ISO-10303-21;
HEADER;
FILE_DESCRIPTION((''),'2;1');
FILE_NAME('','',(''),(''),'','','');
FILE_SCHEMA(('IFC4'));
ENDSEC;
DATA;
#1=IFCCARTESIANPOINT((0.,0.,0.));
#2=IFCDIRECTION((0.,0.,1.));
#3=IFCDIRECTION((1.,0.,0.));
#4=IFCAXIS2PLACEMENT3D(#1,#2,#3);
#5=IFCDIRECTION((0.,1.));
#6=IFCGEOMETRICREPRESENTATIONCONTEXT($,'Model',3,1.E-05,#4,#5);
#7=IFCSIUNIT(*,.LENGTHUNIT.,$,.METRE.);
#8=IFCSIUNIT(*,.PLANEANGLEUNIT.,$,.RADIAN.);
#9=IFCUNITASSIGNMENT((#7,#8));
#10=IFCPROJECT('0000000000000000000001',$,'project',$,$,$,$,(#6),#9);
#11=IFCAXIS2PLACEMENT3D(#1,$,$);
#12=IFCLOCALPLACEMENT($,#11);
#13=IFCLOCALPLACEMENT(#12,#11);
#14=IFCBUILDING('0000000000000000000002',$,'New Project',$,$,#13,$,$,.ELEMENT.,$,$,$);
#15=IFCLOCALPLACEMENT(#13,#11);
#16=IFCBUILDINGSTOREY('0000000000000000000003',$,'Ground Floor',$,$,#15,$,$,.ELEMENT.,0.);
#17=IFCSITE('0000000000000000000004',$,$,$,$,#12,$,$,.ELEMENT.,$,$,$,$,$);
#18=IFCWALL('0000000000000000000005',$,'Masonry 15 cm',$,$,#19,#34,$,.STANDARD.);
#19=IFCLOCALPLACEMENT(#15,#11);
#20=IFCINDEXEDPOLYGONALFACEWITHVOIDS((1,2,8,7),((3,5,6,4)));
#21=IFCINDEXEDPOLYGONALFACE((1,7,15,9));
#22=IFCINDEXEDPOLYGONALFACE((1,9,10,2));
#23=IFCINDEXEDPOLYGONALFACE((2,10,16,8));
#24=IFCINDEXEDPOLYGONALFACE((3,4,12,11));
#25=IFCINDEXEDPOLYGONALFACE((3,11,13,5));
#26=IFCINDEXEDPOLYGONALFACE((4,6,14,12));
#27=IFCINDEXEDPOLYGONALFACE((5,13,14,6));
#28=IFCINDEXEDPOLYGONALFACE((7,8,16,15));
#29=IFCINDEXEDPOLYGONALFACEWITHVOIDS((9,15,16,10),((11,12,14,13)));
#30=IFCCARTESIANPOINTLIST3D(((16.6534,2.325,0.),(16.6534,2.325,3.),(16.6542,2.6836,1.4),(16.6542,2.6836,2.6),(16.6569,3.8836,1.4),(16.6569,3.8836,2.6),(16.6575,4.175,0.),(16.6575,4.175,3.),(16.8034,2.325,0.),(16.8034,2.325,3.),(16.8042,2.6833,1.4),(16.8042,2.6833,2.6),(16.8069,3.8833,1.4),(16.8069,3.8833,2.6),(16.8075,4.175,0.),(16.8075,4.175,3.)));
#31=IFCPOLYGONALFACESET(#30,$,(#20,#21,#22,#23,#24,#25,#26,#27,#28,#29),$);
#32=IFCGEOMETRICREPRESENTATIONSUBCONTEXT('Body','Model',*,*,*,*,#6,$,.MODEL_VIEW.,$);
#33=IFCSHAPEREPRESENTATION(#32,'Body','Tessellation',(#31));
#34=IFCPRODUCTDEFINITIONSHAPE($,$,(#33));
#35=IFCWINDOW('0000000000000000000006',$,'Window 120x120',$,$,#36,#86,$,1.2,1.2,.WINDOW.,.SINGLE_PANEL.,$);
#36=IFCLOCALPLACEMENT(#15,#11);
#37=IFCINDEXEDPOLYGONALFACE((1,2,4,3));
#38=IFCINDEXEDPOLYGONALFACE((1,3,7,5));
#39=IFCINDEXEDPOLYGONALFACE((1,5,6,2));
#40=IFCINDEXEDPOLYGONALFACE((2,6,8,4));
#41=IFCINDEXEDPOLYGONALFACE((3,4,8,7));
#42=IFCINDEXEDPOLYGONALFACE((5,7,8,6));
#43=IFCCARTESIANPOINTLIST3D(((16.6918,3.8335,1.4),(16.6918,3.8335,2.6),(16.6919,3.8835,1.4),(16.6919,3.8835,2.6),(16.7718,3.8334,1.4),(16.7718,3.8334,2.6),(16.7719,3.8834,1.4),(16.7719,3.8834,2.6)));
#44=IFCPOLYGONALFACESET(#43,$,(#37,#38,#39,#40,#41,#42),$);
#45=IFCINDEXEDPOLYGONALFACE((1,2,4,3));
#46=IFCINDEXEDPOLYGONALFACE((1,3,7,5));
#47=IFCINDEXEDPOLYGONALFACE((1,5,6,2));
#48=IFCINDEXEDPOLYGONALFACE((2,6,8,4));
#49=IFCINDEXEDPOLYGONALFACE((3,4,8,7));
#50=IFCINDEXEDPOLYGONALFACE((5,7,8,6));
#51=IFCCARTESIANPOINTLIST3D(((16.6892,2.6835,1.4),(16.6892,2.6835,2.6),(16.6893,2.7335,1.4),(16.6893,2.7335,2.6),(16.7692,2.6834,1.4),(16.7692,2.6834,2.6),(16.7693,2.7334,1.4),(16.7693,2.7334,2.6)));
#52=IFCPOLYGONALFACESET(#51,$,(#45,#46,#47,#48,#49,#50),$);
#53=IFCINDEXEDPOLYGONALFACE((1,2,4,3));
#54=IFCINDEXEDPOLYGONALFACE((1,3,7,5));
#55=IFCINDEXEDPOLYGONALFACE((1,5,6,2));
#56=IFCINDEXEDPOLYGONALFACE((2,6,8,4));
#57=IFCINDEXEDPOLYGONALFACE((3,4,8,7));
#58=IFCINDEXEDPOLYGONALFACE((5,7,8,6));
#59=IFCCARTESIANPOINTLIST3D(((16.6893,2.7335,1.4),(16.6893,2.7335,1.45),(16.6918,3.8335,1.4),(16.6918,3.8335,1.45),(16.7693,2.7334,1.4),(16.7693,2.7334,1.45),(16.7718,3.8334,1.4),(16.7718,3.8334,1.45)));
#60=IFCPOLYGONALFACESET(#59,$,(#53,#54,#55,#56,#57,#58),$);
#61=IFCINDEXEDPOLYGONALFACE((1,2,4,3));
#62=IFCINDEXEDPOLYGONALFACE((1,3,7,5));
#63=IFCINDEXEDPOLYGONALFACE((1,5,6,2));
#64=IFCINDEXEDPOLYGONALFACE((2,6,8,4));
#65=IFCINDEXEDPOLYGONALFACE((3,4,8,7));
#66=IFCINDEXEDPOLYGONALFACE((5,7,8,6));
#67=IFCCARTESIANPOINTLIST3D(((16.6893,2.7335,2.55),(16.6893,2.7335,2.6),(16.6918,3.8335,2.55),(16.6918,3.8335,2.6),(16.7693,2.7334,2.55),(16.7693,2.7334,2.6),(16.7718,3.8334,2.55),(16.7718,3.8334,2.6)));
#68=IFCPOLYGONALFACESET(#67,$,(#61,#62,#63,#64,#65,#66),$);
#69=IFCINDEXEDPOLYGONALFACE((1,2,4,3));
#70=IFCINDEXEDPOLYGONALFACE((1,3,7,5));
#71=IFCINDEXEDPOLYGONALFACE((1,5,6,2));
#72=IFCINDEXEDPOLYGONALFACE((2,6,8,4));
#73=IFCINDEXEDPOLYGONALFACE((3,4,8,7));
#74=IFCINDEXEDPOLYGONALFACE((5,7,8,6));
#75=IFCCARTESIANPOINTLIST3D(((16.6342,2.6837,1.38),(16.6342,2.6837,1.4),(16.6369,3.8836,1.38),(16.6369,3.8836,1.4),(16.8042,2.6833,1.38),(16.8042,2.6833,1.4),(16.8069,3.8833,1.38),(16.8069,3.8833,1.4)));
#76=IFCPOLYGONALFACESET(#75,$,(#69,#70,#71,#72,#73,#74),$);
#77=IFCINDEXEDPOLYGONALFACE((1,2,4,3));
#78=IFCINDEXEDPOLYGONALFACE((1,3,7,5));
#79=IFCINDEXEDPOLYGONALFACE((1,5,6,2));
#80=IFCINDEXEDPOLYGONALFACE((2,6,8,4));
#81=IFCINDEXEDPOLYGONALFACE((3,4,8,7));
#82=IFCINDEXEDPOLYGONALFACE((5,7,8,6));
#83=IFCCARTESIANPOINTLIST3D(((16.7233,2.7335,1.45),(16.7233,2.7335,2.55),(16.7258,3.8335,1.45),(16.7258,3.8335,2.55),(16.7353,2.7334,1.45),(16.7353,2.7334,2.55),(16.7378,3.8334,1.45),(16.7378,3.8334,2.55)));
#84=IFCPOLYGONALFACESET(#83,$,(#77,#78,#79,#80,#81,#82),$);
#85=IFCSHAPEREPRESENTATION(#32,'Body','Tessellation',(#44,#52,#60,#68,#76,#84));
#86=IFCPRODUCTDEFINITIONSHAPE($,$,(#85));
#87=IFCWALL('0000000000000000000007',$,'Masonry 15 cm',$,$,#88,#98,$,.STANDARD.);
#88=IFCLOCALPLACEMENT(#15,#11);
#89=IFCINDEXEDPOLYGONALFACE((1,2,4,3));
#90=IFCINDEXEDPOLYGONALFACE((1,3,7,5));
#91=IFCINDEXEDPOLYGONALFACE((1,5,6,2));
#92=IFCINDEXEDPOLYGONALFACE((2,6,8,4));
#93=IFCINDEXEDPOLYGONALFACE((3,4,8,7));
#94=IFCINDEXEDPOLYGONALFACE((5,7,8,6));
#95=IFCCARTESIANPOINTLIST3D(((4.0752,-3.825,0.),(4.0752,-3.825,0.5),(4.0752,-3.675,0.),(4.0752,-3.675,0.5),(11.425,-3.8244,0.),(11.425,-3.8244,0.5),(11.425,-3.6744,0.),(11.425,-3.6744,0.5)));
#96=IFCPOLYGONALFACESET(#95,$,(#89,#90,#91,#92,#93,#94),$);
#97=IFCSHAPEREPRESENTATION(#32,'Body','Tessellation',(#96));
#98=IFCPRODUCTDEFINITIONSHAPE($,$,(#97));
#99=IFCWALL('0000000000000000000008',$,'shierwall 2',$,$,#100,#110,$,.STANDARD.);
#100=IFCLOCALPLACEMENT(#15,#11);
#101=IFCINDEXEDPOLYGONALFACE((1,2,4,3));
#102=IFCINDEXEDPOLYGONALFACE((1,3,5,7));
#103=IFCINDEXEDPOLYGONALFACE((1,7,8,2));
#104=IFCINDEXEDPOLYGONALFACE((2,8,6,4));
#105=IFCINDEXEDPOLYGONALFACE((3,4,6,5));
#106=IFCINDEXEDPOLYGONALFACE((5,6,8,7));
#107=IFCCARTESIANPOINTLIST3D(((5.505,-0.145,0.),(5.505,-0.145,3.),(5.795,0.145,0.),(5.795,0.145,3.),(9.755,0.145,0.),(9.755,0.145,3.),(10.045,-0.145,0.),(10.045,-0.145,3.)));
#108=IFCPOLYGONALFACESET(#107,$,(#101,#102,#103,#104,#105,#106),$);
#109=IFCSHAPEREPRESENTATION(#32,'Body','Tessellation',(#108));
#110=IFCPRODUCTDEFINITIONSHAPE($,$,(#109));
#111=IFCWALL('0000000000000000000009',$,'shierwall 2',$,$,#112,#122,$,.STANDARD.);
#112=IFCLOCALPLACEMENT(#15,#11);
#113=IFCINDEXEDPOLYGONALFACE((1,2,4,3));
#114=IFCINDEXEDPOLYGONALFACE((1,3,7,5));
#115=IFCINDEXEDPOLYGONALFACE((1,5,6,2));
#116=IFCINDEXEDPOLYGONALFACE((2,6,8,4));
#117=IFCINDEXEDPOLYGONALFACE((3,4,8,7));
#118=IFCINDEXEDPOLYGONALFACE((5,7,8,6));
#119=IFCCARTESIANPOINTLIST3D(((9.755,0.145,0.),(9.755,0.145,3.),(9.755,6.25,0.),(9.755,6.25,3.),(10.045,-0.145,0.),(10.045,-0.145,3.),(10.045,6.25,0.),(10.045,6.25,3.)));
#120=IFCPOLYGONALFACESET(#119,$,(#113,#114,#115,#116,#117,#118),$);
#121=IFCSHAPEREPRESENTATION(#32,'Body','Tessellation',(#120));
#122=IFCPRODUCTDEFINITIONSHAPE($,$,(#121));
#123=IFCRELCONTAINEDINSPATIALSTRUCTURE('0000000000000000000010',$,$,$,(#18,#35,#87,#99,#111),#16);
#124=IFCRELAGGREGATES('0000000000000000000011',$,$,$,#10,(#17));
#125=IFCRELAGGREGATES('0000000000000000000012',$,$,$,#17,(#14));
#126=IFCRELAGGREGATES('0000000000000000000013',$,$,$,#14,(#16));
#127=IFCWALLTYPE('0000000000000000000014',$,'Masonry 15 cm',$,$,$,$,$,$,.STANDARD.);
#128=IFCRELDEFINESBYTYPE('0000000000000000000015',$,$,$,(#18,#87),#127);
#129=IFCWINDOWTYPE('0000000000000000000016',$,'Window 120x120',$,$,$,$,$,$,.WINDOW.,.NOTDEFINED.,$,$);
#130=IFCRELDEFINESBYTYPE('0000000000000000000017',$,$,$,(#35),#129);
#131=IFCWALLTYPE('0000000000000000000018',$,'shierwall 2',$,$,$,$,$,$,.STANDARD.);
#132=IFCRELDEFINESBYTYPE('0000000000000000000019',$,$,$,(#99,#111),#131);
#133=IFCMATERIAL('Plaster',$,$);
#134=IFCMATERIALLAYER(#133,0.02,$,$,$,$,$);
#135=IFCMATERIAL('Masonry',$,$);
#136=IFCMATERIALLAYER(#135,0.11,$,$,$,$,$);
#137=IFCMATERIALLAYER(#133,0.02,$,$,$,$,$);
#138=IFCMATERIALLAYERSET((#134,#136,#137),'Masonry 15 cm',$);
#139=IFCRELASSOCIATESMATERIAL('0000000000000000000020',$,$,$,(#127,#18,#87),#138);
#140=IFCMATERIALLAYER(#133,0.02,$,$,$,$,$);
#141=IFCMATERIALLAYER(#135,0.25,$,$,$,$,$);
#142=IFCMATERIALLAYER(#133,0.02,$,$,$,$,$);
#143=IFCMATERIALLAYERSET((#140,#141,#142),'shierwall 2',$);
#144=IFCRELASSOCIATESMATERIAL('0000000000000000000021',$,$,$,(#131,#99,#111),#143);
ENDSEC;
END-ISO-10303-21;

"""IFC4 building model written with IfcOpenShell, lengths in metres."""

from ifc_helpers import new_model, si_unit, direction, frame, frame_2d, origin, origin_with_axes, place, context, subcontext, project, spatial, polyline, rectangle, outline, extrude, material, layer, layer_set, layer_usage, type_object, element, fill, save


model = new_model("IFC4")

# Units and contexts
model_context = context("Model", 3, precision=1e-05, world=origin_with_axes(), true_north=direction((0.0, 1.0)))
body_context = subcontext(model_context, "Body", "Model", "MODEL_VIEW")
ifc_project = project(units=[si_unit("LENGTHUNIT", "METRE"), si_unit("PLANEANGLEUNIT", "RADIAN")], contexts=[model_context])

# Site, building, storey
site_placement = place(None, origin())
site = spatial("IfcSite", under=ifc_project, at=site_placement, CompositionType="ELEMENT")
building_placement = place(site_placement, origin())
building = spatial("IfcBuilding", under=site, at=building_placement, Name="New Project", CompositionType="ELEMENT")
storey_placement = place(building_placement, origin())
storey = spatial("IfcBuildingStorey", under=building, at=storey_placement, Name="Ground Floor", CompositionType="ELEMENT", Elevation=0.0)

# Shared definitions
ifc_material_1 = material(Name="Plaster")
ifc_layer_1 = layer(ifc_material_1, 0.02)
ifc_material_2 = material(Name="Masonry")
ifc_layer_2 = layer(ifc_material_2, 0.11)
ifc_layer_3 = layer(ifc_material_1, 0.02)
ifc_layer_set_1 = layer_set([ifc_layer_1, ifc_layer_2, ifc_layer_3], Name="Masonry 15 cm")
ifc_layer_usage_1 = layer_usage(ifc_layer_set_1, "AXIS2", "NEGATIVE", 0.075)
wall_type_1 = type_object("IfcWallType", Name="Masonry 15 cm", PredefinedType="STANDARD", material=ifc_layer_set_1)
window_type_1 = type_object("IfcWindowType", Name="Window 120x120", PartitioningType="NOTDEFINED", PredefinedType="WINDOW")

# Wall, opening, window
wall_1_placement = place(storey_placement, frame((16.7283, 2.25, 0.0), z_axis=(0.0, 0.0, 1.0), x_axis=(0.002207, 0.999998, 0.0)))
wall_1 = element("IfcWall", 1, at=wall_1_placement, inside=storey, type_object=wall_type_1, material=ifc_layer_usage_1, Name="Masonry 15 cm", PredefinedType="STANDARD", context=body_context, shape_type="SweptSolid", body=[
    extrude(outline(polyline([(0.0752, -0.075), (1.9252, -0.075), (1.9248, 0.075), (0.0748, 0.075), (0.0752, -0.075)])), origin(), (0.0, 0.0, 1.0), 3.0),
])
opening_1_placement = place(wall_1_placement, frame((0.4334, 0.0, 1.4)))
opening_1 = element("IfcOpeningElement", 2, at=opening_1_placement, cuts=wall_1, PredefinedType="OPENING", context=body_context, shape_type="SweptSolid", body=[
    extrude(rectangle(XDim=1.2, YDim=0.25, at=frame_2d((0.6, 0.0))), origin(), (0.0, 0.0, 1.0), 1.2),
])
window_1_placement = place(opening_1_placement, origin())
window_1 = element("IfcWindow", 3, at=window_1_placement, inside=storey, type_object=window_type_1, Name="Window 120x120", OverallHeight=1.2, OverallWidth=1.2, PartitioningType="SINGLE_PANEL", PredefinedType="WINDOW", context=body_context, shape_type="SweptSolid", body=[
    extrude(outline(polyline([(1.2, 0.04), (1.15, 0.04), (1.15, -0.04), (1.2, -0.04), (1.2, 0.04)])), origin(), (0.0, 0.0, 1.0), 1.2),
    extrude(outline(polyline([(0.05, 0.04), (0.0, 0.04), (0.0, -0.04), (0.05, -0.04), (0.05, 0.04)])), origin(), (0.0, 0.0, 1.0), 1.2),
    extrude(outline(polyline([(1.15, 0.04), (0.05, 0.04), (0.05, -0.04), (1.15, -0.04), (1.15, 0.04)])), origin(), (0.0, 0.0, 1.0), 0.05),
    extrude(outline(polyline([(1.15, 0.04), (0.05, 0.04), (0.05, -0.04), (1.15, -0.04), (1.15, 0.04)])), frame((0.0, 0.0, 1.15)), (0.0, 0.0, 1.0), 0.05),
    extrude(outline(polyline([(1.2, 0.095), (0.0, 0.095), (0.0, -0.075), (1.2, -0.075), (1.2, 0.095)])), frame((0.0, 0.0, -0.02)), (0.0, 0.0, 1.0), 0.02),
    extrude(outline(polyline([(1.15, 0.006), (0.05, 0.006), (0.05, -0.006), (1.15, -0.006), (1.15, 0.006)])), frame((0.0, 0.0, 0.05)), (0.0, 0.0, 1.0), 1.1),
])
fill(opening_1, window_1)

# Walls
wall_2_placement = place(storey_placement, frame((11.425, -3.7494, 0.0), z_axis=(0.0, 0.0, 1.0), x_axis=(-1.0, -0.000079, 0.0)))
element("IfcWall", 4, at=wall_2_placement, inside=storey, type_object=wall_type_1, material=ifc_layer_usage_1, Name="Masonry 15 cm", PredefinedType="STANDARD", context=body_context, shape_type="SweptSolid", body=[
    extrude(outline(polyline([(0.0, -0.075), (7.3498, -0.075), (7.3498, 0.075), (0.0, 0.075), (0.0, -0.075)])), origin(), (0.0, 0.0, 1.0), 0.5),
])
ifc_layer_4 = layer(ifc_material_1, 0.02)
ifc_layer_5 = layer(ifc_material_2, 0.25)
ifc_layer_6 = layer(ifc_material_1, 0.02)
ifc_layer_set_2 = layer_set([ifc_layer_4, ifc_layer_5, ifc_layer_6], Name="shierwall 2")
ifc_layer_usage_2 = layer_usage(ifc_layer_set_2, "AXIS2", "NEGATIVE", 0.145)
wall_type_2 = type_object("IfcWallType", Name="shierwall 2", PredefinedType="STANDARD", material=ifc_layer_set_2)
wall_3_placement = place(storey_placement, frame((5.65, 0.0, 0.0)))
element("IfcWall", 5, at=wall_3_placement, inside=storey, type_object=wall_type_2, material=ifc_layer_usage_2, Name="shierwall 2", PredefinedType="STANDARD", context=body_context, shape_type="SweptSolid", body=[
    extrude(outline(polyline([(-0.145, -0.145), (4.395, -0.145), (4.105, 0.145), (0.145, 0.145), (-0.145, -0.145)])), origin(), (0.0, 0.0, 1.0), 3.0),
])
wall_4_placement = place(storey_placement, frame((9.9, 0.0, 0.0), z_axis=(0.0, 0.0, 1.0), x_axis=(0.0, 1.0, 0.0)))
element("IfcWall", 6, at=wall_4_placement, inside=storey, type_object=wall_type_2, material=ifc_layer_usage_2, Name="shierwall 2", PredefinedType="STANDARD", context=body_context, shape_type="SweptSolid", body=[
    extrude(outline(polyline([(-0.145, -0.145), (6.25, -0.145), (6.25, 0.145), (0.145, 0.145), (-0.145, -0.145)])), origin(), (0.0, 0.0, 1.0), 3.0),
])

save(model, "model.ifc")
